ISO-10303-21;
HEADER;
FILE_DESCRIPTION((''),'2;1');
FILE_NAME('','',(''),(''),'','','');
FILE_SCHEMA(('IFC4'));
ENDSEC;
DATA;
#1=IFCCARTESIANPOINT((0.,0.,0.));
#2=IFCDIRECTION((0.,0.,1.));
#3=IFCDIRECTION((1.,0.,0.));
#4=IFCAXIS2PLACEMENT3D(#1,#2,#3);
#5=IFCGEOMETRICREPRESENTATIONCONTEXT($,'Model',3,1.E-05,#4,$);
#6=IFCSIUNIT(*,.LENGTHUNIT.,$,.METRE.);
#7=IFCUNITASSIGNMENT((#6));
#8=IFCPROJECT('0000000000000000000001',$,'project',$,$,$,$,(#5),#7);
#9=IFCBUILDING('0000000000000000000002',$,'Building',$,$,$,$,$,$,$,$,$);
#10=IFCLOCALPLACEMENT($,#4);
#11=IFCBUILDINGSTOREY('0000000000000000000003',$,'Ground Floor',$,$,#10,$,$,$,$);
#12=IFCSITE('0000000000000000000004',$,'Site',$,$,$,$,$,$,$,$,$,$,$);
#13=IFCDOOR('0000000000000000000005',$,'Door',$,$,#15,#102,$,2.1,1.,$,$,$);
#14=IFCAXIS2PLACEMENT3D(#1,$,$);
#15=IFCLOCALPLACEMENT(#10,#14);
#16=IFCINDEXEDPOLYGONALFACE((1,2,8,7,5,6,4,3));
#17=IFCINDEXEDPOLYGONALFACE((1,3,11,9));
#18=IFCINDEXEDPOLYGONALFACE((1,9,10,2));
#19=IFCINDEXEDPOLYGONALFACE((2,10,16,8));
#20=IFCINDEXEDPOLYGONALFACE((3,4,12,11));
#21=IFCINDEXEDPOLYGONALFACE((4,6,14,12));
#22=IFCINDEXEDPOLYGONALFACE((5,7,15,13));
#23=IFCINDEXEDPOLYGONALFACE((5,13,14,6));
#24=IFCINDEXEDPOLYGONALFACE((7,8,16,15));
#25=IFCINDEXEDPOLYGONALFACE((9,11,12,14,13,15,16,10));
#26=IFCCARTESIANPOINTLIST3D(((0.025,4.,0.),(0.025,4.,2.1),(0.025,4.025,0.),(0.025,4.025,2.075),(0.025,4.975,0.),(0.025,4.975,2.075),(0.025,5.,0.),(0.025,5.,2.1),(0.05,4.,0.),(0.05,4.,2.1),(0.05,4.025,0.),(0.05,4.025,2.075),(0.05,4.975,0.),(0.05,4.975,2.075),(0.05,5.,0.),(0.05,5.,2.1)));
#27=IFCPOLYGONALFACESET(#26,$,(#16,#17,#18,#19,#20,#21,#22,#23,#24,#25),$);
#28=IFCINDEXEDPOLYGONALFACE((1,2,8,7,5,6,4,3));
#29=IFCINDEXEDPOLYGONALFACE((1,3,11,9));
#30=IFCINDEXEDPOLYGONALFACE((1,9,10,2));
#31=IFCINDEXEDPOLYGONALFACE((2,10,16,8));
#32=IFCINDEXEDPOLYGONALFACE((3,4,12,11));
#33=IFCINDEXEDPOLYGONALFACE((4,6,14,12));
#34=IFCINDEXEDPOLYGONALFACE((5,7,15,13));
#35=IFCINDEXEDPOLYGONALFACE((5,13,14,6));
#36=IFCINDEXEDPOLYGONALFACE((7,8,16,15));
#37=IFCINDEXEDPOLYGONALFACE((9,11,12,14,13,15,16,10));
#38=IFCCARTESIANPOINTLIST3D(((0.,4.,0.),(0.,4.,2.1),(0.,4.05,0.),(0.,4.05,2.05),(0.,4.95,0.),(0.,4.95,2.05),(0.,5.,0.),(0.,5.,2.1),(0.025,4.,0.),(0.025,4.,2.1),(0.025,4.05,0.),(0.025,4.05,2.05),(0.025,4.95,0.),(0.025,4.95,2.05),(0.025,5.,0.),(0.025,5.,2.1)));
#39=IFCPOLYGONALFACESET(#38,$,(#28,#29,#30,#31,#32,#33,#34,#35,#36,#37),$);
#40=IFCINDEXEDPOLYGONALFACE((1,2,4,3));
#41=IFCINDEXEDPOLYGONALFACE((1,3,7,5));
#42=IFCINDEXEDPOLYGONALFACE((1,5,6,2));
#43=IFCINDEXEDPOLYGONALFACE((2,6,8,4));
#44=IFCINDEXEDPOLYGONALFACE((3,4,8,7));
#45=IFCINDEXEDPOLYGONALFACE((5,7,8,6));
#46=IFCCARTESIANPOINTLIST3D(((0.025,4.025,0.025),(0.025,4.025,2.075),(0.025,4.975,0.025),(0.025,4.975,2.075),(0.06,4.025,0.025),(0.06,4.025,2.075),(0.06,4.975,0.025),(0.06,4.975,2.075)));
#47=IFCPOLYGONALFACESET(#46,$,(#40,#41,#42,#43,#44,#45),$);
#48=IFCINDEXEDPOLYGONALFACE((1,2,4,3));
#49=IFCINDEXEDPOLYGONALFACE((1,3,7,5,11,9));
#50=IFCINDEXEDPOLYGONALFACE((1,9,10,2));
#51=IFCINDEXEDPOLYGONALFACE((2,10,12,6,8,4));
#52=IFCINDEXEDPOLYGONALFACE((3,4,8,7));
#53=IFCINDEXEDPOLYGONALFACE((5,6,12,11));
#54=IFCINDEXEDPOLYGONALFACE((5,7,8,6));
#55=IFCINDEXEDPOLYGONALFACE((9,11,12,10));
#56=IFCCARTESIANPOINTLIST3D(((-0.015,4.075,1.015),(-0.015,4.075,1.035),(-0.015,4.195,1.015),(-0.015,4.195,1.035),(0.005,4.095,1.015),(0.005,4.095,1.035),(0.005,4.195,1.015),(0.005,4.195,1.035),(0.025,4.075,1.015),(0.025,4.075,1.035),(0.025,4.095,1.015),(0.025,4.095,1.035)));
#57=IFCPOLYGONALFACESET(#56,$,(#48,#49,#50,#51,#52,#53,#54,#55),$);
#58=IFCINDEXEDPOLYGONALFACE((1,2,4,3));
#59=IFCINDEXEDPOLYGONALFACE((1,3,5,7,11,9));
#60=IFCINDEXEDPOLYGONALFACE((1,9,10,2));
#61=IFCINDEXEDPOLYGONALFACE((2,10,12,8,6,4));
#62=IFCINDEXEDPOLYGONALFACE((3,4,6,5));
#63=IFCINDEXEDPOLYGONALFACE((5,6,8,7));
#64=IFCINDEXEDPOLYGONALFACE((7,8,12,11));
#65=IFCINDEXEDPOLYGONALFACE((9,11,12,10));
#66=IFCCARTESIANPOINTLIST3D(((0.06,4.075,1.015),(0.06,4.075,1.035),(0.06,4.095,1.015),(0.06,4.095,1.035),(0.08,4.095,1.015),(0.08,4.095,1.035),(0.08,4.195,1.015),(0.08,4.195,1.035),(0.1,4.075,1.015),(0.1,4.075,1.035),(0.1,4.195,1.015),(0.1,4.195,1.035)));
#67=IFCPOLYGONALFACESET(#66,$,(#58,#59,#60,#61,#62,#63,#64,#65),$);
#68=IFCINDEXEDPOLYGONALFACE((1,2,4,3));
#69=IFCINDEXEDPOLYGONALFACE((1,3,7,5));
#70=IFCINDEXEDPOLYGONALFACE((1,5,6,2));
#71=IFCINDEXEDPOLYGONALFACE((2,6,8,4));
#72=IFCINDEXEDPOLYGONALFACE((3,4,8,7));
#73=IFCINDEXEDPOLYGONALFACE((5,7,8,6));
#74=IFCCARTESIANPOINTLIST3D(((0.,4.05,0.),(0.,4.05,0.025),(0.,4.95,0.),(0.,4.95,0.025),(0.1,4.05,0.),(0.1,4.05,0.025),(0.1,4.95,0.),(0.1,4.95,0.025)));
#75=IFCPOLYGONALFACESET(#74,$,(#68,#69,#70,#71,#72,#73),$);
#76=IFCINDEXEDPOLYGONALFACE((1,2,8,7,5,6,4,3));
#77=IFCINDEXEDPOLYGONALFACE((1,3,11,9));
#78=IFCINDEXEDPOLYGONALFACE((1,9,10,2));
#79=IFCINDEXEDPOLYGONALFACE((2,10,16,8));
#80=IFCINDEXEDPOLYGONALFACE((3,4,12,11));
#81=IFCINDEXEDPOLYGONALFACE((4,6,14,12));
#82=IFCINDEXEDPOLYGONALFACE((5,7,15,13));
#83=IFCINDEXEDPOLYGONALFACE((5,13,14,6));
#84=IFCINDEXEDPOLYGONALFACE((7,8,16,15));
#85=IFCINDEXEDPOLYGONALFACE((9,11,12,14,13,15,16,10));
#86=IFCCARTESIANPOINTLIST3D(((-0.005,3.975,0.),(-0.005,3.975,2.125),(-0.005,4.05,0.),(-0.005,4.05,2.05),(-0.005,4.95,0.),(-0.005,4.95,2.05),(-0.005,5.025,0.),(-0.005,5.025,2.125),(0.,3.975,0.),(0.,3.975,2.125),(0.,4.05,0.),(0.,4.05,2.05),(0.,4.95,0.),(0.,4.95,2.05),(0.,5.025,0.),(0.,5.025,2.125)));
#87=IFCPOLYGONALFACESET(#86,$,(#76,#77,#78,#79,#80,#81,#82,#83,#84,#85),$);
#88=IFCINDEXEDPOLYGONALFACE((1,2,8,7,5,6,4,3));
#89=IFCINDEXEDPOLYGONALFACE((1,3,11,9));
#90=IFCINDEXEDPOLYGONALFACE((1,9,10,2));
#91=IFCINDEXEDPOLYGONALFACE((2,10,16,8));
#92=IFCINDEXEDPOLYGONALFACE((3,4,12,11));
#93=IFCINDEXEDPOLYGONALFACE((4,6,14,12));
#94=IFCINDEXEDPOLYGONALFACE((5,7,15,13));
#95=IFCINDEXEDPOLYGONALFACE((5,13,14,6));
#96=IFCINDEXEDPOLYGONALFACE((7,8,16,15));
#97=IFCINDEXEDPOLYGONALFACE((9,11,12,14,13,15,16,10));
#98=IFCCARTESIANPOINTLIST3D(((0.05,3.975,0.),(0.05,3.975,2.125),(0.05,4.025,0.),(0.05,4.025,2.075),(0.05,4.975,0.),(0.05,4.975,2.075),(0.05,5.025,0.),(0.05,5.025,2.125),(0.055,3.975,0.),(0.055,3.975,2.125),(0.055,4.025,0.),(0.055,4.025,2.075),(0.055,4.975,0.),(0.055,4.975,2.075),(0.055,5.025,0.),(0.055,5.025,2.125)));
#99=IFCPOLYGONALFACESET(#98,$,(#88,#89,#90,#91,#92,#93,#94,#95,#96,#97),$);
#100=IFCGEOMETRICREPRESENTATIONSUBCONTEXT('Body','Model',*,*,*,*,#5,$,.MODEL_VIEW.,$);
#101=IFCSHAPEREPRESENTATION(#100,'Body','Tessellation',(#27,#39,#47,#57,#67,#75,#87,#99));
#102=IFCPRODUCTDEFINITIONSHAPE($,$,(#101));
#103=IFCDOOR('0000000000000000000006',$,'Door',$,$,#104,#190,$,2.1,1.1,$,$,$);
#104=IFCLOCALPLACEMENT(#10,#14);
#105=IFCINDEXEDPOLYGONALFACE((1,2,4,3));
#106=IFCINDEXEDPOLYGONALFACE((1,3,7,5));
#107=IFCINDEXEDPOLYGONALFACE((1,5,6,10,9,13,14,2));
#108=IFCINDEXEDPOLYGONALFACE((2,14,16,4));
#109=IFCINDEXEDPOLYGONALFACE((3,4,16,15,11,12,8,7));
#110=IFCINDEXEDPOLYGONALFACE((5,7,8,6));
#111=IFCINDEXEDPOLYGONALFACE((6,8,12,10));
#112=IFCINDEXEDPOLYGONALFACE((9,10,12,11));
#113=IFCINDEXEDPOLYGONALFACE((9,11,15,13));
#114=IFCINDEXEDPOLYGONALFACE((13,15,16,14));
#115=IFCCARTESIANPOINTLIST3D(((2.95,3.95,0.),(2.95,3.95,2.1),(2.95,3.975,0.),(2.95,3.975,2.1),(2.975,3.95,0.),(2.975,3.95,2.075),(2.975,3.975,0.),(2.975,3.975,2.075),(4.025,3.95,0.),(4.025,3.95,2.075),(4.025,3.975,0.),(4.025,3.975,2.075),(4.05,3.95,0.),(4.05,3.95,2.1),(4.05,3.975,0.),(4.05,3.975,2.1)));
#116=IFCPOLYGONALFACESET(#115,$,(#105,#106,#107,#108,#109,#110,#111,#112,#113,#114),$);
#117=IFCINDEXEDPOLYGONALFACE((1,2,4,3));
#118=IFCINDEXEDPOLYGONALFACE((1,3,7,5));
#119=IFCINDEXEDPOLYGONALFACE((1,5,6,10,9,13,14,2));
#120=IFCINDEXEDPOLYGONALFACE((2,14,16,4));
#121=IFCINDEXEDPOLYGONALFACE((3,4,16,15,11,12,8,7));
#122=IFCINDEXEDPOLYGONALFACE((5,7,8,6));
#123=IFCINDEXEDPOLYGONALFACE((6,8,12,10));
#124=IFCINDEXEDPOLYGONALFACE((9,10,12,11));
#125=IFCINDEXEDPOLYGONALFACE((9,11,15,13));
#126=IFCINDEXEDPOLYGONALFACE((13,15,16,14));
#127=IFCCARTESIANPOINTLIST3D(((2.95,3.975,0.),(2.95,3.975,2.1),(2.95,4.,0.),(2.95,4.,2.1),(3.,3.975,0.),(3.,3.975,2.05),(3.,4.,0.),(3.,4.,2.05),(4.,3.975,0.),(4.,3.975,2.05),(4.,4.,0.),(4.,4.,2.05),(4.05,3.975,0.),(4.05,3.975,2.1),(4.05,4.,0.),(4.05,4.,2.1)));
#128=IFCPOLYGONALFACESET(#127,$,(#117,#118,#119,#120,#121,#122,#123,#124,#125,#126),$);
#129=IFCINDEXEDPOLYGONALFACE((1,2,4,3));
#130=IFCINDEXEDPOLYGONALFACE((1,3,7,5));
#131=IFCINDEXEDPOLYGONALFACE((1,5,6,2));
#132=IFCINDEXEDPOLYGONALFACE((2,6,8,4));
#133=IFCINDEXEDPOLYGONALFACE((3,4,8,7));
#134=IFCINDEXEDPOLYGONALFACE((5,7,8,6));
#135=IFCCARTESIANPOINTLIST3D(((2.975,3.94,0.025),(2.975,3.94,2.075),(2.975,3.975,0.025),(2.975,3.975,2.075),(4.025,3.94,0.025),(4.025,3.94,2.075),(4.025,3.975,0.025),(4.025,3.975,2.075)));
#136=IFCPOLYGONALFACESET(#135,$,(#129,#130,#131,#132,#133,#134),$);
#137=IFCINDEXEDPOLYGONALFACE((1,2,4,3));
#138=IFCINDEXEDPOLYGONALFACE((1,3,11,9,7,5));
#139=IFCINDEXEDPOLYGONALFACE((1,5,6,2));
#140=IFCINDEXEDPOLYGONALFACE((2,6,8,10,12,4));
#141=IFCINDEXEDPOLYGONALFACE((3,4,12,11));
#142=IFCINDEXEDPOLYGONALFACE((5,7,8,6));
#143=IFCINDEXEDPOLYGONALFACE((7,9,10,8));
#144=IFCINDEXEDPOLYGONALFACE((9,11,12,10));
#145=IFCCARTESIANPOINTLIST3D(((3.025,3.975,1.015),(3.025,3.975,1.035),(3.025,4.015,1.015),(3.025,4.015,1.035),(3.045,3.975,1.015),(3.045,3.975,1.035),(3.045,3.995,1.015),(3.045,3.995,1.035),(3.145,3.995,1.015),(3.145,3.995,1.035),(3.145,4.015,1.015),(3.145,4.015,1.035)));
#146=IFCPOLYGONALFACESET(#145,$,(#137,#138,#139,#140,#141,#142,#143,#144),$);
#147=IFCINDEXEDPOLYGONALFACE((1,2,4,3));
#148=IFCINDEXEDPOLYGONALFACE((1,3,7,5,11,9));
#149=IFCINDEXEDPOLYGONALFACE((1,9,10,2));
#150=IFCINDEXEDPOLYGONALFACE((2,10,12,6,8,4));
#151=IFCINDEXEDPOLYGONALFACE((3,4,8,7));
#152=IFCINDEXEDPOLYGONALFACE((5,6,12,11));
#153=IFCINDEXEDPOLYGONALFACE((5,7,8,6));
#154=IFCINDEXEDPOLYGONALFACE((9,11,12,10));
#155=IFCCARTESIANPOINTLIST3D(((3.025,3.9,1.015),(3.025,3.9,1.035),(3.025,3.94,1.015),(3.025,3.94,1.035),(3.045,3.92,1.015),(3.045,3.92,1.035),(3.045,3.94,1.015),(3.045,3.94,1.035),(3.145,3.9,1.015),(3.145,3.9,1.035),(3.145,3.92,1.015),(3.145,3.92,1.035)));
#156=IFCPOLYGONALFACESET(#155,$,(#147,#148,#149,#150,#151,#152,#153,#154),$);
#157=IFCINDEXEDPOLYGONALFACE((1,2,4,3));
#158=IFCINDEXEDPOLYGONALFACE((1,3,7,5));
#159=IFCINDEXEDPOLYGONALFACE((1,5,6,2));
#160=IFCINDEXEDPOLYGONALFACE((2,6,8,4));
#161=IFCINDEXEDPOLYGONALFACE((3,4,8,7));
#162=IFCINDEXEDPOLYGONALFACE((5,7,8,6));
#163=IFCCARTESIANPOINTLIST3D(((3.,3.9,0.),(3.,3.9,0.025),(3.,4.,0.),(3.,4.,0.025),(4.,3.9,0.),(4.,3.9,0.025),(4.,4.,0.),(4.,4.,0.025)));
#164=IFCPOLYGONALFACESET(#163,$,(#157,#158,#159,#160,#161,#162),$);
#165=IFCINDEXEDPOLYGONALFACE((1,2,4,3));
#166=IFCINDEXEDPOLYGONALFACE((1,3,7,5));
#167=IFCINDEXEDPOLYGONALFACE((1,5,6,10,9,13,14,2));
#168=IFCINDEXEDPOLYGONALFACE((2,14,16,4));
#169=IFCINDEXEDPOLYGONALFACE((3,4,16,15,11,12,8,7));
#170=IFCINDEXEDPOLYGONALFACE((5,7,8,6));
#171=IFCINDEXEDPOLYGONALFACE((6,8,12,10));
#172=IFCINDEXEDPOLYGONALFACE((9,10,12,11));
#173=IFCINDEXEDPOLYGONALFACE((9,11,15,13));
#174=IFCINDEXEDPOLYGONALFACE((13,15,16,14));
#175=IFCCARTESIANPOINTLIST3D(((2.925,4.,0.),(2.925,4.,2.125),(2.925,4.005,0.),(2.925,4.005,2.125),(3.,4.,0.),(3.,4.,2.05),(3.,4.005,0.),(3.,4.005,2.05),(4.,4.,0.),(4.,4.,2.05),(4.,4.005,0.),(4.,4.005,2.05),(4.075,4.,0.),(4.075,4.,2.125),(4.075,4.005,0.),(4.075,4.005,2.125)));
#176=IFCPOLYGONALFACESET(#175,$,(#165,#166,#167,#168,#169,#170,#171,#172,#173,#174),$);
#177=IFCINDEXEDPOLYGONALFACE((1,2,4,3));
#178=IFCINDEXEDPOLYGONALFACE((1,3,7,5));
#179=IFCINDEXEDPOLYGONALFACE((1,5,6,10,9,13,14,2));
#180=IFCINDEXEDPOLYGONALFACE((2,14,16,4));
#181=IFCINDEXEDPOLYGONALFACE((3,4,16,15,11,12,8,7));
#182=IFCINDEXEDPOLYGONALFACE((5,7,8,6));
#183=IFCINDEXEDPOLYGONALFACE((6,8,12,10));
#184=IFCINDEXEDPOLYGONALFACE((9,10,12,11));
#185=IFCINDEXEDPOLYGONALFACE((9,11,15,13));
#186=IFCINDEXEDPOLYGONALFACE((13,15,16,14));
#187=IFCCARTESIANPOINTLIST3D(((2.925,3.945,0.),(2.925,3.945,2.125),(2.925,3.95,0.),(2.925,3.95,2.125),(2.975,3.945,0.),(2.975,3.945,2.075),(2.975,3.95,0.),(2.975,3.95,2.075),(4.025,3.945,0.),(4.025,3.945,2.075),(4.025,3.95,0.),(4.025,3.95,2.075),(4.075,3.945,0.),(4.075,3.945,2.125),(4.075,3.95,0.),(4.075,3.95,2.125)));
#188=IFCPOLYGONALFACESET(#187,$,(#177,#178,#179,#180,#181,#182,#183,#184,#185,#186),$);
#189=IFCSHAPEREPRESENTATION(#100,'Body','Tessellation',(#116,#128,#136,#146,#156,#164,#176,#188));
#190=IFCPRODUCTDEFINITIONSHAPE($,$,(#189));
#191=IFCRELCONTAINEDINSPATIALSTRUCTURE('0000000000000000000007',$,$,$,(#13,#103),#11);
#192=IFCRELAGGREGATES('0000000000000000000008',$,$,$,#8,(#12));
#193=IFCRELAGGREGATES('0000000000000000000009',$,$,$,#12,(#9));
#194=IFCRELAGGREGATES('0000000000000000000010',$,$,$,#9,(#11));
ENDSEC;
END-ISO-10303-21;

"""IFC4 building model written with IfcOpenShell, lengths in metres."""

from ifc_helpers import new_model, si_unit, frame, origin_with_axes, place, context, subcontext, project, spatial, line, indexed_curve, outline, extrude, element, save


model = new_model("IFC4")

# Units and contexts
model_context = context("Model", 3, precision=1e-05, world=origin_with_axes())
body_context = subcontext(model_context, "Body", "Model", "MODEL_VIEW")
ifc_project = project(units=[si_unit("LENGTHUNIT", "METRE")], contexts=[model_context])

# Site, building, storey
site = spatial("IfcSite", under=ifc_project, Name="Site")
building = spatial("IfcBuilding", under=site, Name="Building")
storey_placement = place(None, origin_with_axes())
storey = spatial("IfcBuildingStorey", under=building, at=storey_placement, Name="Ground Floor")

# Doors
door_1_placement = place(storey_placement, frame((0.0, 5.0, 0.0), z_axis=(0.0, 0.0, 1.0), x_axis=(0.0, -1.0, 0.0)))
element("IfcDoor", 1, at=door_1_placement, inside=storey, Name="Door", OverallHeight=2.1, OverallWidth=1.0, context=body_context, shape_type="SweptSolid", body=[
    extrude(outline(indexed_curve([(0.0, 0.0), (0.0, 2.1), (1.0, 2.1), (1.0, 0.0), (0.975, 0.0), (0.975, 2.075), (0.025, 2.075), (0.025, 0.0)], segments=[line(1, 2, 3, 4, 5, 6, 7, 8, 1)])), frame((0.0, 0.025, 0.0), z_axis=(0.0, -1.0, 0.0), x_axis=(1.0, 0.0, 0.0)), (0.0, 0.0, -1.0), 0.025),
    extrude(outline(indexed_curve([(0.0, 0.0), (0.0, 2.1), (1.0, 2.1), (1.0, 0.0), (0.95, 0.0), (0.95, 2.05), (0.05, 2.05), (0.05, 0.0)], segments=[line(1, 2, 3, 4, 5, 6, 7, 8, 1)])), frame((0.0, 0.0, 0.0), z_axis=(0.0, -1.0, 0.0), x_axis=(1.0, 0.0, 0.0)), (0.0, 0.0, -1.0), 0.025),
    extrude(outline(indexed_curve([(0.0, 0.0), (0.95, 0.0), (0.95, 0.035), (0.0, 0.035)], segments=[line(1, 2, 3, 4, 1)])), frame((0.025, 0.025, 0.025), z_axis=(0.0, 0.0, 1.0), x_axis=(1.0, 0.0, 0.0)), (0.0, 0.0, 1.0), 2.05),
    extrude(outline(indexed_curve([(0.0, 0.0), (0.0, -0.04), (-0.12, -0.04), (-0.12, -0.02), (-0.02, -0.02), (-0.02, 0.0)], segments=[line(1, 2, 3, 4, 5, 6, 1)])), frame((0.925, 0.025, 1.015), z_axis=(0.0, 0.0, 1.0), x_axis=(1.0, 0.0, 0.0)), (0.0, 0.0, 1.0), 0.02),
    extrude(outline(indexed_curve([(0.0, 0.0), (0.0, 0.04), (-0.12, 0.04), (-0.12, 0.02), (-0.02, 0.02), (-0.02, 0.0)], segments=[line(1, 2, 3, 4, 5, 6, 1)])), frame((0.925, 0.06, 1.015), z_axis=(0.0, 0.0, 1.0), x_axis=(1.0, 0.0, 0.0)), (0.0, 0.0, 1.0), 0.02),
    extrude(outline(indexed_curve([(0.0, 0.0), (0.9, 0.0), (0.9, 0.1), (0.0, 0.1)], segments=[line(1, 2, 3, 4, 1)])), frame((0.05, 0.0, 0.0), z_axis=(0.0, 0.0, 1.0), x_axis=(1.0, 0.0, 0.0)), (0.0, 0.0, 1.0), 0.025),
    extrude(outline(indexed_curve([(0.0, 0.0), (0.0, 2.125), (1.05, 2.125), (1.05, 0.0), (0.975, 0.0), (0.975, 2.05), (0.075, 2.05), (0.075, 0.0)], segments=[line(1, 2, 3, 4, 5, 6, 7, 8, 1)])), frame((-0.025, -0.005, 0.0), z_axis=(0.0, -1.0, 0.0), x_axis=(1.0, 0.0, 0.0)), (0.0, 0.0, -1.0), 0.005),
    extrude(outline(indexed_curve([(0.0, 0.0), (0.0, 2.125), (1.05, 2.125), (1.05, 0.0), (1.0, 0.0), (1.0, 2.075), (0.05, 2.075), (0.05, 0.0)], segments=[line(1, 2, 3, 4, 5, 6, 7, 8, 1)])), frame((-0.025, 0.05, 0.0), z_axis=(0.0, -1.0, 0.0), x_axis=(1.0, 0.0, 0.0)), (0.0, 0.0, -1.0), 0.005),
])
door_2_placement = place(storey_placement, frame((4.05, 4.0, 0.0), z_axis=(0.0, 0.0, 1.0), x_axis=(-1.0, 0.0, 0.0)))
element("IfcDoor", 2, at=door_2_placement, inside=storey, Name="Door", OverallHeight=2.1, OverallWidth=1.1, context=body_context, shape_type="SweptSolid", body=[
    extrude(outline(indexed_curve([(0.0, 0.0), (0.0, 2.1), (1.1, 2.1), (1.1, 0.0), (1.075, 0.0), (1.075, 2.075), (0.025, 2.075), (0.025, 0.0)], segments=[line(1, 2, 3, 4, 5, 6, 7, 8, 1)])), frame((0.0, 0.025, 0.0), z_axis=(0.0, -1.0, 0.0), x_axis=(1.0, 0.0, 0.0)), (0.0, 0.0, -1.0), 0.025),
    extrude(outline(indexed_curve([(0.0, 0.0), (0.0, 2.1), (1.1, 2.1), (1.1, 0.0), (1.05, 0.0), (1.05, 2.05), (0.05, 2.05), (0.05, 0.0)], segments=[line(1, 2, 3, 4, 5, 6, 7, 8, 1)])), frame((0.0, 0.0, 0.0), z_axis=(0.0, -1.0, 0.0), x_axis=(1.0, 0.0, 0.0)), (0.0, 0.0, -1.0), 0.025),
    extrude(outline(indexed_curve([(0.0, 0.0), (1.05, 0.0), (1.05, 0.035), (0.0, 0.035)], segments=[line(1, 2, 3, 4, 1)])), frame((0.025, 0.025, 0.025), z_axis=(0.0, 0.0, 1.0), x_axis=(1.0, 0.0, 0.0)), (0.0, 0.0, 1.0), 2.05),
    extrude(outline(indexed_curve([(0.0, 0.0), (0.0, -0.04), (-0.12, -0.04), (-0.12, -0.02), (-0.02, -0.02), (-0.02, 0.0)], segments=[line(1, 2, 3, 4, 5, 6, 1)])), frame((1.025, 0.025, 1.015), z_axis=(0.0, 0.0, 1.0), x_axis=(1.0, 0.0, 0.0)), (0.0, 0.0, 1.0), 0.02),
    extrude(outline(indexed_curve([(0.0, 0.0), (0.0, 0.04), (-0.12, 0.04), (-0.12, 0.02), (-0.02, 0.02), (-0.02, 0.0)], segments=[line(1, 2, 3, 4, 5, 6, 1)])), frame((1.025, 0.06, 1.015), z_axis=(0.0, 0.0, 1.0), x_axis=(1.0, 0.0, 0.0)), (0.0, 0.0, 1.0), 0.02),
    extrude(outline(indexed_curve([(0.0, 0.0), (1.0, 0.0), (1.0, 0.1), (0.0, 0.1)], segments=[line(1, 2, 3, 4, 1)])), frame((0.05, 0.0, 0.0), z_axis=(0.0, 0.0, 1.0), x_axis=(1.0, 0.0, 0.0)), (0.0, 0.0, 1.0), 0.025),
    extrude(outline(indexed_curve([(0.0, 0.0), (0.0, 2.125), (1.15, 2.125), (1.15, 0.0), (1.075, 0.0), (1.075, 2.05), (0.075, 2.05), (0.075, 0.0)], segments=[line(1, 2, 3, 4, 5, 6, 7, 8, 1)])), frame((-0.025, -0.005, 0.0), z_axis=(0.0, -1.0, 0.0), x_axis=(1.0, 0.0, 0.0)), (0.0, 0.0, -1.0), 0.005),
    extrude(outline(indexed_curve([(0.0, 0.0), (0.0, 2.125), (1.15, 2.125), (1.15, 0.0), (1.1, 0.0), (1.1, 2.075), (0.05, 2.075), (0.05, 0.0)], segments=[line(1, 2, 3, 4, 5, 6, 7, 8, 1)])), frame((-0.025, 0.05, 0.0), z_axis=(0.0, -1.0, 0.0), x_axis=(1.0, 0.0, 0.0)), (0.0, 0.0, -1.0), 0.005),
])

save(model, "model.ifc")
